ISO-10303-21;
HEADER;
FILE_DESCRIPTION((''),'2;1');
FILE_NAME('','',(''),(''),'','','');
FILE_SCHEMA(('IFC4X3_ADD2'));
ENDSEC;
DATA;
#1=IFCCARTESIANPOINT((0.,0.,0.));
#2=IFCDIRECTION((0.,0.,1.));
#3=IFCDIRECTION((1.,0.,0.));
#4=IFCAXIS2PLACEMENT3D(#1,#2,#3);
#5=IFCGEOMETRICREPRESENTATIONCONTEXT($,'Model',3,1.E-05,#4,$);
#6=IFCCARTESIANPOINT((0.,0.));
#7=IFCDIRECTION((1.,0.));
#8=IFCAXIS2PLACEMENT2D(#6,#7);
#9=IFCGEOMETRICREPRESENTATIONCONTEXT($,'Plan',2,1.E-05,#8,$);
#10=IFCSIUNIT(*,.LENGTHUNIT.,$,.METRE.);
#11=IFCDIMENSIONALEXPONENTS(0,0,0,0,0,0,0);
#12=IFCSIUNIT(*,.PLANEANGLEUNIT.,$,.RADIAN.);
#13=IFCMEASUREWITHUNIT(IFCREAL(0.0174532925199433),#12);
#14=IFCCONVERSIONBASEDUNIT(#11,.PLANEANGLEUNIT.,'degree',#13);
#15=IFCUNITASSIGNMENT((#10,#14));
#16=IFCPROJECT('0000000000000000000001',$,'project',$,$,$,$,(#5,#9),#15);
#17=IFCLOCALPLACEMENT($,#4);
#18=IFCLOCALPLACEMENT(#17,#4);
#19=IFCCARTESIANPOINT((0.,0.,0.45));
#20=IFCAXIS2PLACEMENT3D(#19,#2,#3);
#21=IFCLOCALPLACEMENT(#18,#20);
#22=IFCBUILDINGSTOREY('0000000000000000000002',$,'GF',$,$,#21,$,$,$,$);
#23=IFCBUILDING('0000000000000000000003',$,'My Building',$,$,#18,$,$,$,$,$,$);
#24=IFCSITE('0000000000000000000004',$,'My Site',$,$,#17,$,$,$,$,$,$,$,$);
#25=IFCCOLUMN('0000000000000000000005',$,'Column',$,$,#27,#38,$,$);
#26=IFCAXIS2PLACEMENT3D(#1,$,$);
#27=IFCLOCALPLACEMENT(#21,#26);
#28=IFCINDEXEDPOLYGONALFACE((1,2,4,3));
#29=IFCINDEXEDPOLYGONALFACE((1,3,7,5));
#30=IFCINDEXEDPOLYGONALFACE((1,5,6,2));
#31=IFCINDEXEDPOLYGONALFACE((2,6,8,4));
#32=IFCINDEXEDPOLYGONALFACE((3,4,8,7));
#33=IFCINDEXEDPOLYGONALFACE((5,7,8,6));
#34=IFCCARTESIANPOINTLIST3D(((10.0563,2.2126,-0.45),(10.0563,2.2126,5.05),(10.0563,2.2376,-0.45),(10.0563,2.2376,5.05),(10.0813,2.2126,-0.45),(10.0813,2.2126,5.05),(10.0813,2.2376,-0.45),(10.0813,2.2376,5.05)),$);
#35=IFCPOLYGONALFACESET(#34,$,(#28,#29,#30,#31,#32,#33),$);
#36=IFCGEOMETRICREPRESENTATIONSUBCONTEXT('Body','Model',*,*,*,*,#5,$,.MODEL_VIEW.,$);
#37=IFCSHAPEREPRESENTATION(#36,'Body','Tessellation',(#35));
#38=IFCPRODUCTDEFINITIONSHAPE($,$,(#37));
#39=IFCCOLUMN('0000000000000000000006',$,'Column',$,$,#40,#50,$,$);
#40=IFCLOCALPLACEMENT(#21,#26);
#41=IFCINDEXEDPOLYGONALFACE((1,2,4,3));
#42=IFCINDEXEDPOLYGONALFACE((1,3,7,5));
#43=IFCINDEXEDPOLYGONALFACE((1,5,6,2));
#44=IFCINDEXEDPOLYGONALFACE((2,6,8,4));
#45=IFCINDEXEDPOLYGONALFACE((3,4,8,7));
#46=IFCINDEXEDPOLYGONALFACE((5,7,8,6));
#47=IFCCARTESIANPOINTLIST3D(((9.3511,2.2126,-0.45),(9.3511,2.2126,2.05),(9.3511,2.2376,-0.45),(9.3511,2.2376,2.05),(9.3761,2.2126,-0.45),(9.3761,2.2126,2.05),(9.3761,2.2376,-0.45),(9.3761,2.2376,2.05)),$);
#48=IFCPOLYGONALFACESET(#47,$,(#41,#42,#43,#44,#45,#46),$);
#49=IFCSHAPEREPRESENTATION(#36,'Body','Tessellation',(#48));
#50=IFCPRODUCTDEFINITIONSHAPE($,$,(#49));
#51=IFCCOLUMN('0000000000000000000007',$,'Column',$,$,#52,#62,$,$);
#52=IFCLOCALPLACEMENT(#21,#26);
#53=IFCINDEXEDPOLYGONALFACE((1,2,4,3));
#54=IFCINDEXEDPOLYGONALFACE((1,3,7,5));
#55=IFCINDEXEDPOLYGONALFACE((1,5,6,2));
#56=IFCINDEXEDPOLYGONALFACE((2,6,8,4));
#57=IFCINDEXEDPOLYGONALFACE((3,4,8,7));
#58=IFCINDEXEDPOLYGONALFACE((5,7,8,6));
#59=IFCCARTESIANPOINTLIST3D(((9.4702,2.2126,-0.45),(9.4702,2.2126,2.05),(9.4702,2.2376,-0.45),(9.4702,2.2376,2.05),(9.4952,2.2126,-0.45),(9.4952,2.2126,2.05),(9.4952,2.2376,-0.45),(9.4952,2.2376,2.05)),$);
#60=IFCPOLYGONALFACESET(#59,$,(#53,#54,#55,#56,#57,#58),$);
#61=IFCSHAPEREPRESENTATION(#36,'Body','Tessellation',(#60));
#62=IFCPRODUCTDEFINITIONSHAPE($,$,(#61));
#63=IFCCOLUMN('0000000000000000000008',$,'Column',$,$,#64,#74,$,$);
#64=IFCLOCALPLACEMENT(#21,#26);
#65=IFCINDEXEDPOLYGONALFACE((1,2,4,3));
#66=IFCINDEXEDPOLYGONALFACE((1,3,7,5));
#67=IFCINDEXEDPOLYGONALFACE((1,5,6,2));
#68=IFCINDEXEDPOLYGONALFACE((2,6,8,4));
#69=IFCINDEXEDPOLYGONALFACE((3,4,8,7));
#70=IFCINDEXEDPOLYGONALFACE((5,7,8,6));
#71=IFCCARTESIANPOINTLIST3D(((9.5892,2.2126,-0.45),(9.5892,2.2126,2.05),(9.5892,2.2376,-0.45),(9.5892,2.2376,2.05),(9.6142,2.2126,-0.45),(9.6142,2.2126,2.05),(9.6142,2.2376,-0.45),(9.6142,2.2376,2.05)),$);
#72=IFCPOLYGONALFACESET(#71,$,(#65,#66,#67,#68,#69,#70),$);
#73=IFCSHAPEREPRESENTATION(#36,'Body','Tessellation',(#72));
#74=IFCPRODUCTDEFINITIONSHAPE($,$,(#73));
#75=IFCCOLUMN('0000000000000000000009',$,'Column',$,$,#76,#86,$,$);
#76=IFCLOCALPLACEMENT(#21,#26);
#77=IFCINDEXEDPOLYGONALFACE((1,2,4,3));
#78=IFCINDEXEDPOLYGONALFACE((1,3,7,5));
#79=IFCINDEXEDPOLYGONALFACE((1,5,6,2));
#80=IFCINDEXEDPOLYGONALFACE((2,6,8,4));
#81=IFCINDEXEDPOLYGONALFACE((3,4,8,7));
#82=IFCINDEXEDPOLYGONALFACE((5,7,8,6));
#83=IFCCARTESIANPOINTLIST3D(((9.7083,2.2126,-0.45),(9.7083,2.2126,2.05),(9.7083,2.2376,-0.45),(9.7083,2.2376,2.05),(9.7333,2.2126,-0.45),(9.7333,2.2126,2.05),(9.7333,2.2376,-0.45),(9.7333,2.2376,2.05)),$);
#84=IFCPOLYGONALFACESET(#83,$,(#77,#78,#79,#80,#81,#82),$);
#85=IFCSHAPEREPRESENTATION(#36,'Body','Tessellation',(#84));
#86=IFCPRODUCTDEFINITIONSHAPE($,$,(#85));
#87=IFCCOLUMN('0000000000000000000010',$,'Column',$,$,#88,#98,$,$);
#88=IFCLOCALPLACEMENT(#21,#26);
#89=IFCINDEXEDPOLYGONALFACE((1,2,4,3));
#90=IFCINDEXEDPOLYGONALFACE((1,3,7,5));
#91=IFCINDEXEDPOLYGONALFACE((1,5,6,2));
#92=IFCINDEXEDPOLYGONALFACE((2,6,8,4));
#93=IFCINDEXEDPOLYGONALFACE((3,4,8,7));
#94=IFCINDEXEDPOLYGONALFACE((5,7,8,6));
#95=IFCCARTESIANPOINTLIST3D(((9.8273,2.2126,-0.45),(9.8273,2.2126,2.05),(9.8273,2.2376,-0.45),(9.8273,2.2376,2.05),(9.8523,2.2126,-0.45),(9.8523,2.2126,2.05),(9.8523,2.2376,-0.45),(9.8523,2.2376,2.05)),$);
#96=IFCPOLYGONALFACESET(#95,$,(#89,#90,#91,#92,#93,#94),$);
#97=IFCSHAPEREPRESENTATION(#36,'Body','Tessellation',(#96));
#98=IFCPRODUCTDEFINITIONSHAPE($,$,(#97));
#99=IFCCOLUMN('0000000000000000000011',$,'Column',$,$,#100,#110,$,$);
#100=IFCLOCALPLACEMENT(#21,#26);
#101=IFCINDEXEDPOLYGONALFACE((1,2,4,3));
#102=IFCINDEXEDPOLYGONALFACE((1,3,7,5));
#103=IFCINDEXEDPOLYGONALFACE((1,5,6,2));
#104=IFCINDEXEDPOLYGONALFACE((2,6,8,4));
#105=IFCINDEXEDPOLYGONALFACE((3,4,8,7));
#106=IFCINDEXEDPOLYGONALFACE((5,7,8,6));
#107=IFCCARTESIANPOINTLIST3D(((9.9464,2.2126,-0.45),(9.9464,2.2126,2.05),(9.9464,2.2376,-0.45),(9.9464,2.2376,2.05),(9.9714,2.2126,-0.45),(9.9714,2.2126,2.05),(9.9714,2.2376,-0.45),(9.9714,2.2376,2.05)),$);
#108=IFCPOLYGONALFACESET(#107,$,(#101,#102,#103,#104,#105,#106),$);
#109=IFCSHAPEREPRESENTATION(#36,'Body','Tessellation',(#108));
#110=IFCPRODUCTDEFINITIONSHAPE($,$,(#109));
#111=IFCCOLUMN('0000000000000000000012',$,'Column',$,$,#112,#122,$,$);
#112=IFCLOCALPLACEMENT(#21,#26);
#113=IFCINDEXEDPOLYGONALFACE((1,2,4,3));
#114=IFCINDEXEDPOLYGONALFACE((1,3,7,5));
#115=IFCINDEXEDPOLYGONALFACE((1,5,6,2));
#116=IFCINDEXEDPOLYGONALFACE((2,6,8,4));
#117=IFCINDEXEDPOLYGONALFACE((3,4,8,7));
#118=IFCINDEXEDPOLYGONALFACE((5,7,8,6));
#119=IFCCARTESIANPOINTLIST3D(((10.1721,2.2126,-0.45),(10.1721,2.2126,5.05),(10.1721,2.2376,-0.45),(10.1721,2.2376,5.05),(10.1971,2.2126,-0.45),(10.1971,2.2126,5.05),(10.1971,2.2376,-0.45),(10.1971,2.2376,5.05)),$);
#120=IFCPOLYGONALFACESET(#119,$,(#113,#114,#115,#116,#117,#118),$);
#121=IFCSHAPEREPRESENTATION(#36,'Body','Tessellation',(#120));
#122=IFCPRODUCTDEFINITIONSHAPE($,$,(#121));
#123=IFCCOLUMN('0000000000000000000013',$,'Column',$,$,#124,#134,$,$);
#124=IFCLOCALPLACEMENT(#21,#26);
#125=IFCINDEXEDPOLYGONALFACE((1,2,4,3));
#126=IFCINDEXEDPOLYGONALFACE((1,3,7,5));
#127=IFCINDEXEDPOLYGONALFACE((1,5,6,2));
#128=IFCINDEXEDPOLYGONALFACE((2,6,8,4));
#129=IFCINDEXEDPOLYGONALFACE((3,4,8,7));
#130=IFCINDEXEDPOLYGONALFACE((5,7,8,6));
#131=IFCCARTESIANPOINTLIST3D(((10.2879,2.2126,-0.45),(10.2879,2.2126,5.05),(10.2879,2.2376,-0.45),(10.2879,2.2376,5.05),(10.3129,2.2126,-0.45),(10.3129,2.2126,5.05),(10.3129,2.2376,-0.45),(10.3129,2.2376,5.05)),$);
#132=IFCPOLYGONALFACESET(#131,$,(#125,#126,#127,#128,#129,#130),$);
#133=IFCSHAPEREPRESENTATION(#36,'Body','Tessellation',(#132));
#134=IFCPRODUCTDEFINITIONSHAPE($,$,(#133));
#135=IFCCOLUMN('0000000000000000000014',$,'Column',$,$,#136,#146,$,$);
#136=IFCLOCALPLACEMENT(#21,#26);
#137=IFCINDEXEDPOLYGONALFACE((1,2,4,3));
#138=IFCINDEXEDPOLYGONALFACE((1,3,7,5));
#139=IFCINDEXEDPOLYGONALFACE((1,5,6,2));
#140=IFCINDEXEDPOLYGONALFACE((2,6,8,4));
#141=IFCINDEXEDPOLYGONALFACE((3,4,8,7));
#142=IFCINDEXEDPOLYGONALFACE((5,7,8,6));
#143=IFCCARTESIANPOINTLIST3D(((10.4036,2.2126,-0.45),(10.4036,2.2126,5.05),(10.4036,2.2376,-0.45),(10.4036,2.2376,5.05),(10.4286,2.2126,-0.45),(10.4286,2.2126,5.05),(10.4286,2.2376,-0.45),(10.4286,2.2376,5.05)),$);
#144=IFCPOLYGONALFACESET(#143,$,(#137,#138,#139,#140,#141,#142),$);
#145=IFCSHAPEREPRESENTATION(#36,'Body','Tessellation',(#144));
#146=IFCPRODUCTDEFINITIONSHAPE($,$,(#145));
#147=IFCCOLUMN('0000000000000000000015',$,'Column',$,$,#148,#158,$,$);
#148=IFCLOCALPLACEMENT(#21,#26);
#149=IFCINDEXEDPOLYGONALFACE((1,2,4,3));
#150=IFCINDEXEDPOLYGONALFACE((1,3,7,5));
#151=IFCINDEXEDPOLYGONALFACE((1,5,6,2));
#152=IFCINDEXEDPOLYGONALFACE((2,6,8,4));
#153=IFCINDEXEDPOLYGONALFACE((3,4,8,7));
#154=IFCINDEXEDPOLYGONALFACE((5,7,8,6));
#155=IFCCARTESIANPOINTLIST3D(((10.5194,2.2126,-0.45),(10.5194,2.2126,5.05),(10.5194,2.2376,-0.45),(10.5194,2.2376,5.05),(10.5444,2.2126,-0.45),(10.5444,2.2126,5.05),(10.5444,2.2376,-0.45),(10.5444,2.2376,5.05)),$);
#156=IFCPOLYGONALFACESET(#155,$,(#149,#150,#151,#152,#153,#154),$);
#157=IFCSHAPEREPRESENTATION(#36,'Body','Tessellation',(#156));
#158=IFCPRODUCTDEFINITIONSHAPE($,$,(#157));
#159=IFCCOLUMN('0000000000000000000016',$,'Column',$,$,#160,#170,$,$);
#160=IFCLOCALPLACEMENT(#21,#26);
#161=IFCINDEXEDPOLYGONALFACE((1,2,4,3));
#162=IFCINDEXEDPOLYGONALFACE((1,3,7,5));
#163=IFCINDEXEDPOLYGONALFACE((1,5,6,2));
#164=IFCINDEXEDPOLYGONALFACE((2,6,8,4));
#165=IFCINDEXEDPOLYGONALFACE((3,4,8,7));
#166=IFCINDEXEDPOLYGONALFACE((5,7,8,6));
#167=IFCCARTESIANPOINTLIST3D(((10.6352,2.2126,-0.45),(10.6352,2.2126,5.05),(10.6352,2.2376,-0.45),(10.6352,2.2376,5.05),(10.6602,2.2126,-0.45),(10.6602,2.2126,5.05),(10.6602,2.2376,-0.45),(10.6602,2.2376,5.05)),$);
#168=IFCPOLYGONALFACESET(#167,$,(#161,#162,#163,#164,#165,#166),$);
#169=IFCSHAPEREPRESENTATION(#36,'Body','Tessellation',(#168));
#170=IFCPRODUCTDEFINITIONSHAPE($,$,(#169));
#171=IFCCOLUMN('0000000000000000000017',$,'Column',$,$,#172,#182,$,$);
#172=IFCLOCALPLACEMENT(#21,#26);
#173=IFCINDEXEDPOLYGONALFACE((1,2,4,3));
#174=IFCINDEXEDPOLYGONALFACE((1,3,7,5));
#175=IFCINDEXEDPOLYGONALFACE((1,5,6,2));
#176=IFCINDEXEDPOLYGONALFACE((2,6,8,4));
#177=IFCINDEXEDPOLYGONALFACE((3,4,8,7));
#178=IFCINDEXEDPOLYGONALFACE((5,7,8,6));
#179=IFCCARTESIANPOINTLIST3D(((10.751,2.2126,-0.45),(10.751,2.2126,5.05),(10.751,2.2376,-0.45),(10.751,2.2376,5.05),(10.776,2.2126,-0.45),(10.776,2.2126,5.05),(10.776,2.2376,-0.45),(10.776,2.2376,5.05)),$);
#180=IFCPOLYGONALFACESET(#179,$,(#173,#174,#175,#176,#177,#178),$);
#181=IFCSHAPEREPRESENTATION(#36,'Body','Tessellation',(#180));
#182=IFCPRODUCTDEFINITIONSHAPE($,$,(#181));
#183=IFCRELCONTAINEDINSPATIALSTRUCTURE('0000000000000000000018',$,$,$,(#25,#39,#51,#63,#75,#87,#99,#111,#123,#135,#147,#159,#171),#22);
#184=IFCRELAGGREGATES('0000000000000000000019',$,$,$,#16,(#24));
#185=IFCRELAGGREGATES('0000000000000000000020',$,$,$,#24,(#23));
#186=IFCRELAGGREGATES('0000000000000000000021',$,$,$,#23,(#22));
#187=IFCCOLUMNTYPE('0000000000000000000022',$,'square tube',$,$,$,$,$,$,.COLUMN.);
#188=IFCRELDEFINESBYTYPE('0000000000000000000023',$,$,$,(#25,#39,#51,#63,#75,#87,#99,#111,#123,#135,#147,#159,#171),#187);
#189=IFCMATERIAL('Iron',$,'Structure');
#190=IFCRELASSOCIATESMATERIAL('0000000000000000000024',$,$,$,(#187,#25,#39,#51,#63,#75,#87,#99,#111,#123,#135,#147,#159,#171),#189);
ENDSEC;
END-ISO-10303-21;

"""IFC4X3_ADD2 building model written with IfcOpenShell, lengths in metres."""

from ifc_helpers import new_model, entity, si_unit, converted_unit, frame, origin_with_axes, origin_2d_with_axis, place, context, subcontext, project, spatial, indexed_curve, outline, extrude, material, material_profile, profile_set, profile_usage, type_object, element, save


model = new_model("IFC4X3_ADD2")

# Units and contexts
model_context = context("Model", 3, precision=1e-05, world=origin_with_axes())
plan_context = context("Plan", 2, precision=1e-05, world=origin_2d_with_axis())
body_context_1 = subcontext(model_context, "Body", "Model", "MODEL_VIEW")
ifc_project = project(units=[si_unit("LENGTHUNIT", "METRE"), converted_unit("PLANEANGLEUNIT", "degree", entity("IfcReal", 0.0174532925199433), si_unit("PLANEANGLEUNIT", "RADIAN"), dimensions=[0, 0, 0, 0, 0, 0, 0])], contexts=[model_context, plan_context])

# Site, building, storey
site_placement = place(None, origin_with_axes())
site = spatial("IfcSite", under=ifc_project, at=site_placement, Name="My Site")
building_placement = place(site_placement, origin_with_axes())
building = spatial("IfcBuilding", under=site, at=building_placement, Name="My Building")
storey_placement = place(building_placement, frame((0.0, 0.0, 0.45), z_axis=(0.0, 0.0, 1.0), x_axis=(1.0, 0.0, 0.0)))
storey = spatial("IfcBuildingStorey", under=building, at=storey_placement, Name="GF")

# Columns
ifc_material_1 = material(Name="Iron", Category="Structure")
ifc_material_profile = material_profile(ifc_material_1, outline(indexed_curve([(-0.0125, -0.0125), (0.0125, -0.0125), (0.0125, 0.0125), (-0.0125, 0.0125), (-0.0125, -0.0125)])))
ifc_profile_set = profile_set([ifc_material_profile])
ifc_profile_usage_1 = profile_usage(ifc_profile_set, cardinal=5)
column_type = type_object("IfcColumnType", Name="square tube", PredefinedType="COLUMN", material=ifc_profile_set)
column_1_placement = place(storey_placement, frame((10.0688, 2.2251, -0.45), z_axis=(0.0, 0.0, 1.0), x_axis=(1.0, 0.0, 0.0)))
element("IfcColumn", 1, at=column_1_placement, inside=storey, type_object=column_type, material=ifc_profile_usage_1, Name="Column", context=body_context_1, shape_type="SweptSolid", body=[
    extrude(outline(indexed_curve([(-0.0125, -0.0125), (0.0125, -0.0125), (0.0125, 0.0125), (-0.0125, 0.0125), (-0.0125, -0.0125)])), origin_with_axes(), (0.0, 0.0, 1.0), 5.5),
])
ifc_profile_usage_2 = profile_usage(ifc_profile_set, cardinal=5)
column_2_placement = place(storey_placement, frame((9.3636, 2.2251, -0.45), z_axis=(0.0, 0.0, 1.0), x_axis=(1.0, 0.0, 0.0)))
element("IfcColumn", 2, at=column_2_placement, inside=storey, type_object=column_type, material=ifc_profile_usage_2, Name="Column", context=body_context_1, shape_type="SweptSolid", body=[
    extrude(outline(indexed_curve([(-0.0125, -0.0125), (0.0125, -0.0125), (0.0125, 0.0125), (-0.0125, 0.0125), (-0.0125, -0.0125)])), origin_with_axes(), (0.0, 0.0, 1.0), 2.5),
])
ifc_profile_usage_3 = profile_usage(ifc_profile_set, cardinal=5)
column_3_placement = place(storey_placement, frame((9.4827, 2.2251, -0.45), z_axis=(0.0, 0.0, 1.0), x_axis=(1.0, 0.0, 0.0)))
element("IfcColumn", 3, at=column_3_placement, inside=storey, type_object=column_type, material=ifc_profile_usage_3, Name="Column", context=body_context_1, shape_type="SweptSolid", body=[
    extrude(outline(indexed_curve([(-0.0125, -0.0125), (0.0125, -0.0125), (0.0125, 0.0125), (-0.0125, 0.0125), (-0.0125, -0.0125)])), origin_with_axes(), (0.0, 0.0, 1.0), 2.5),
])
ifc_profile_usage_4 = profile_usage(ifc_profile_set, cardinal=5)
column_4_placement = place(storey_placement, frame((9.6017, 2.2251, -0.45), z_axis=(0.0, 0.0, 1.0), x_axis=(1.0, 0.0, 0.0)))
element("IfcColumn", 4, at=column_4_placement, inside=storey, type_object=column_type, material=ifc_profile_usage_4, Name="Column", context=body_context_1, shape_type="SweptSolid", body=[
    extrude(outline(indexed_curve([(-0.0125, -0.0125), (0.0125, -0.0125), (0.0125, 0.0125), (-0.0125, 0.0125), (-0.0125, -0.0125)])), origin_with_axes(), (0.0, 0.0, 1.0), 2.5),
])
ifc_profile_usage_5 = profile_usage(ifc_profile_set, cardinal=5)
column_5_placement = place(storey_placement, frame((9.7208, 2.2251, -0.45), z_axis=(0.0, 0.0, 1.0), x_axis=(1.0, 0.0, 0.0)))
element("IfcColumn", 5, at=column_5_placement, inside=storey, type_object=column_type, material=ifc_profile_usage_5, Name="Column", context=body_context_1, shape_type="SweptSolid", body=[
    extrude(outline(indexed_curve([(-0.0125, -0.0125), (0.0125, -0.0125), (0.0125, 0.0125), (-0.0125, 0.0125), (-0.0125, -0.0125)])), origin_with_axes(), (0.0, 0.0, 1.0), 2.5),
])
ifc_profile_usage_6 = profile_usage(ifc_profile_set, cardinal=5)
column_6_placement = place(storey_placement, frame((9.8398, 2.2251, -0.45), z_axis=(0.0, 0.0, 1.0), x_axis=(1.0, 0.0, 0.0)))
element("IfcColumn", 6, at=column_6_placement, inside=storey, type_object=column_type, material=ifc_profile_usage_6, Name="Column", context=body_context_1, shape_type="SweptSolid", body=[
    extrude(outline(indexed_curve([(-0.0125, -0.0125), (0.0125, -0.0125), (0.0125, 0.0125), (-0.0125, 0.0125), (-0.0125, -0.0125)])), origin_with_axes(), (0.0, 0.0, 1.0), 2.5),
])
ifc_profile_usage_7 = profile_usage(ifc_profile_set, cardinal=5)
column_7_placement = place(storey_placement, frame((9.9589, 2.2251, -0.45), z_axis=(0.0, 0.0, 1.0), x_axis=(1.0, 0.0, 0.0)))
element("IfcColumn", 7, at=column_7_placement, inside=storey, type_object=column_type, material=ifc_profile_usage_7, Name="Column", context=body_context_1, shape_type="SweptSolid", body=[
    extrude(outline(indexed_curve([(-0.0125, -0.0125), (0.0125, -0.0125), (0.0125, 0.0125), (-0.0125, 0.0125), (-0.0125, -0.0125)])), origin_with_axes(), (0.0, 0.0, 1.0), 2.5),
])
ifc_profile_usage_8 = profile_usage(ifc_profile_set, cardinal=5)
column_8_placement = place(storey_placement, frame((10.1846, 2.2251, -0.45), z_axis=(0.0, 0.0, 1.0), x_axis=(1.0, 0.0, 0.0)))
element("IfcColumn", 8, at=column_8_placement, inside=storey, type_object=column_type, material=ifc_profile_usage_8, Name="Column", context=body_context_1, shape_type="SweptSolid", body=[
    extrude(outline(indexed_curve([(-0.0125, -0.0125), (0.0125, -0.0125), (0.0125, 0.0125), (-0.0125, 0.0125), (-0.0125, -0.0125)])), origin_with_axes(), (0.0, 0.0, 1.0), 5.5),
])
ifc_profile_usage_9 = profile_usage(ifc_profile_set, cardinal=5)
column_9_placement = place(storey_placement, frame((10.3004, 2.2251, -0.45), z_axis=(0.0, 0.0, 1.0), x_axis=(1.0, 0.0, 0.0)))
element("IfcColumn", 9, at=column_9_placement, inside=storey, type_object=column_type, material=ifc_profile_usage_9, Name="Column", context=body_context_1, shape_type="SweptSolid", body=[
    extrude(outline(indexed_curve([(-0.0125, -0.0125), (0.0125, -0.0125), (0.0125, 0.0125), (-0.0125, 0.0125), (-0.0125, -0.0125)])), origin_with_axes(), (0.0, 0.0, 1.0), 5.5),
])
ifc_profile_usage_10 = profile_usage(ifc_profile_set, cardinal=5)
column_10_placement = place(storey_placement, frame((10.4161, 2.2251, -0.45), z_axis=(0.0, 0.0, 1.0), x_axis=(1.0, 0.0, 0.0)))
element("IfcColumn", 10, at=column_10_placement, inside=storey, type_object=column_type, material=ifc_profile_usage_10, Name="Column", context=body_context_1, shape_type="SweptSolid", body=[
    extrude(outline(indexed_curve([(-0.0125, -0.0125), (0.0125, -0.0125), (0.0125, 0.0125), (-0.0125, 0.0125), (-0.0125, -0.0125)])), origin_with_axes(), (0.0, 0.0, 1.0), 5.5),
])
ifc_profile_usage_11 = profile_usage(ifc_profile_set, cardinal=5)
column_11_placement = place(storey_placement, frame((10.5319, 2.2251, -0.45), z_axis=(0.0, 0.0, 1.0), x_axis=(1.0, 0.0, 0.0)))
element("IfcColumn", 11, at=column_11_placement, inside=storey, type_object=column_type, material=ifc_profile_usage_11, Name="Column", context=body_context_1, shape_type="SweptSolid", body=[
    extrude(outline(indexed_curve([(-0.0125, -0.0125), (0.0125, -0.0125), (0.0125, 0.0125), (-0.0125, 0.0125), (-0.0125, -0.0125)])), origin_with_axes(), (0.0, 0.0, 1.0), 5.5),
])
ifc_profile_usage_12 = profile_usage(ifc_profile_set, cardinal=5)
column_12_placement = place(storey_placement, frame((10.6477, 2.2251, -0.45), z_axis=(0.0, 0.0, 1.0), x_axis=(1.0, 0.0, 0.0)))
element("IfcColumn", 12, at=column_12_placement, inside=storey, type_object=column_type, material=ifc_profile_usage_12, Name="Column", context=body_context_1, shape_type="SweptSolid", body=[
    extrude(outline(indexed_curve([(-0.0125, -0.0125), (0.0125, -0.0125), (0.0125, 0.0125), (-0.0125, 0.0125), (-0.0125, -0.0125)])), origin_with_axes(), (0.0, 0.0, 1.0), 5.5),
])
ifc_profile_usage_13 = profile_usage(ifc_profile_set, cardinal=5)
column_13_placement = place(storey_placement, frame((10.7635, 2.2251, -0.45), z_axis=(0.0, 0.0, 1.0), x_axis=(1.0, 0.0, 0.0)))
element("IfcColumn", 13, at=column_13_placement, inside=storey, type_object=column_type, material=ifc_profile_usage_13, Name="Column", context=body_context_1, shape_type="SweptSolid", body=[
    extrude(outline(indexed_curve([(-0.0125, -0.0125), (0.0125, -0.0125), (0.0125, 0.0125), (-0.0125, 0.0125), (-0.0125, -0.0125)])), origin_with_axes(), (0.0, 0.0, 1.0), 5.5),
])

save(model, "model.ifc")
